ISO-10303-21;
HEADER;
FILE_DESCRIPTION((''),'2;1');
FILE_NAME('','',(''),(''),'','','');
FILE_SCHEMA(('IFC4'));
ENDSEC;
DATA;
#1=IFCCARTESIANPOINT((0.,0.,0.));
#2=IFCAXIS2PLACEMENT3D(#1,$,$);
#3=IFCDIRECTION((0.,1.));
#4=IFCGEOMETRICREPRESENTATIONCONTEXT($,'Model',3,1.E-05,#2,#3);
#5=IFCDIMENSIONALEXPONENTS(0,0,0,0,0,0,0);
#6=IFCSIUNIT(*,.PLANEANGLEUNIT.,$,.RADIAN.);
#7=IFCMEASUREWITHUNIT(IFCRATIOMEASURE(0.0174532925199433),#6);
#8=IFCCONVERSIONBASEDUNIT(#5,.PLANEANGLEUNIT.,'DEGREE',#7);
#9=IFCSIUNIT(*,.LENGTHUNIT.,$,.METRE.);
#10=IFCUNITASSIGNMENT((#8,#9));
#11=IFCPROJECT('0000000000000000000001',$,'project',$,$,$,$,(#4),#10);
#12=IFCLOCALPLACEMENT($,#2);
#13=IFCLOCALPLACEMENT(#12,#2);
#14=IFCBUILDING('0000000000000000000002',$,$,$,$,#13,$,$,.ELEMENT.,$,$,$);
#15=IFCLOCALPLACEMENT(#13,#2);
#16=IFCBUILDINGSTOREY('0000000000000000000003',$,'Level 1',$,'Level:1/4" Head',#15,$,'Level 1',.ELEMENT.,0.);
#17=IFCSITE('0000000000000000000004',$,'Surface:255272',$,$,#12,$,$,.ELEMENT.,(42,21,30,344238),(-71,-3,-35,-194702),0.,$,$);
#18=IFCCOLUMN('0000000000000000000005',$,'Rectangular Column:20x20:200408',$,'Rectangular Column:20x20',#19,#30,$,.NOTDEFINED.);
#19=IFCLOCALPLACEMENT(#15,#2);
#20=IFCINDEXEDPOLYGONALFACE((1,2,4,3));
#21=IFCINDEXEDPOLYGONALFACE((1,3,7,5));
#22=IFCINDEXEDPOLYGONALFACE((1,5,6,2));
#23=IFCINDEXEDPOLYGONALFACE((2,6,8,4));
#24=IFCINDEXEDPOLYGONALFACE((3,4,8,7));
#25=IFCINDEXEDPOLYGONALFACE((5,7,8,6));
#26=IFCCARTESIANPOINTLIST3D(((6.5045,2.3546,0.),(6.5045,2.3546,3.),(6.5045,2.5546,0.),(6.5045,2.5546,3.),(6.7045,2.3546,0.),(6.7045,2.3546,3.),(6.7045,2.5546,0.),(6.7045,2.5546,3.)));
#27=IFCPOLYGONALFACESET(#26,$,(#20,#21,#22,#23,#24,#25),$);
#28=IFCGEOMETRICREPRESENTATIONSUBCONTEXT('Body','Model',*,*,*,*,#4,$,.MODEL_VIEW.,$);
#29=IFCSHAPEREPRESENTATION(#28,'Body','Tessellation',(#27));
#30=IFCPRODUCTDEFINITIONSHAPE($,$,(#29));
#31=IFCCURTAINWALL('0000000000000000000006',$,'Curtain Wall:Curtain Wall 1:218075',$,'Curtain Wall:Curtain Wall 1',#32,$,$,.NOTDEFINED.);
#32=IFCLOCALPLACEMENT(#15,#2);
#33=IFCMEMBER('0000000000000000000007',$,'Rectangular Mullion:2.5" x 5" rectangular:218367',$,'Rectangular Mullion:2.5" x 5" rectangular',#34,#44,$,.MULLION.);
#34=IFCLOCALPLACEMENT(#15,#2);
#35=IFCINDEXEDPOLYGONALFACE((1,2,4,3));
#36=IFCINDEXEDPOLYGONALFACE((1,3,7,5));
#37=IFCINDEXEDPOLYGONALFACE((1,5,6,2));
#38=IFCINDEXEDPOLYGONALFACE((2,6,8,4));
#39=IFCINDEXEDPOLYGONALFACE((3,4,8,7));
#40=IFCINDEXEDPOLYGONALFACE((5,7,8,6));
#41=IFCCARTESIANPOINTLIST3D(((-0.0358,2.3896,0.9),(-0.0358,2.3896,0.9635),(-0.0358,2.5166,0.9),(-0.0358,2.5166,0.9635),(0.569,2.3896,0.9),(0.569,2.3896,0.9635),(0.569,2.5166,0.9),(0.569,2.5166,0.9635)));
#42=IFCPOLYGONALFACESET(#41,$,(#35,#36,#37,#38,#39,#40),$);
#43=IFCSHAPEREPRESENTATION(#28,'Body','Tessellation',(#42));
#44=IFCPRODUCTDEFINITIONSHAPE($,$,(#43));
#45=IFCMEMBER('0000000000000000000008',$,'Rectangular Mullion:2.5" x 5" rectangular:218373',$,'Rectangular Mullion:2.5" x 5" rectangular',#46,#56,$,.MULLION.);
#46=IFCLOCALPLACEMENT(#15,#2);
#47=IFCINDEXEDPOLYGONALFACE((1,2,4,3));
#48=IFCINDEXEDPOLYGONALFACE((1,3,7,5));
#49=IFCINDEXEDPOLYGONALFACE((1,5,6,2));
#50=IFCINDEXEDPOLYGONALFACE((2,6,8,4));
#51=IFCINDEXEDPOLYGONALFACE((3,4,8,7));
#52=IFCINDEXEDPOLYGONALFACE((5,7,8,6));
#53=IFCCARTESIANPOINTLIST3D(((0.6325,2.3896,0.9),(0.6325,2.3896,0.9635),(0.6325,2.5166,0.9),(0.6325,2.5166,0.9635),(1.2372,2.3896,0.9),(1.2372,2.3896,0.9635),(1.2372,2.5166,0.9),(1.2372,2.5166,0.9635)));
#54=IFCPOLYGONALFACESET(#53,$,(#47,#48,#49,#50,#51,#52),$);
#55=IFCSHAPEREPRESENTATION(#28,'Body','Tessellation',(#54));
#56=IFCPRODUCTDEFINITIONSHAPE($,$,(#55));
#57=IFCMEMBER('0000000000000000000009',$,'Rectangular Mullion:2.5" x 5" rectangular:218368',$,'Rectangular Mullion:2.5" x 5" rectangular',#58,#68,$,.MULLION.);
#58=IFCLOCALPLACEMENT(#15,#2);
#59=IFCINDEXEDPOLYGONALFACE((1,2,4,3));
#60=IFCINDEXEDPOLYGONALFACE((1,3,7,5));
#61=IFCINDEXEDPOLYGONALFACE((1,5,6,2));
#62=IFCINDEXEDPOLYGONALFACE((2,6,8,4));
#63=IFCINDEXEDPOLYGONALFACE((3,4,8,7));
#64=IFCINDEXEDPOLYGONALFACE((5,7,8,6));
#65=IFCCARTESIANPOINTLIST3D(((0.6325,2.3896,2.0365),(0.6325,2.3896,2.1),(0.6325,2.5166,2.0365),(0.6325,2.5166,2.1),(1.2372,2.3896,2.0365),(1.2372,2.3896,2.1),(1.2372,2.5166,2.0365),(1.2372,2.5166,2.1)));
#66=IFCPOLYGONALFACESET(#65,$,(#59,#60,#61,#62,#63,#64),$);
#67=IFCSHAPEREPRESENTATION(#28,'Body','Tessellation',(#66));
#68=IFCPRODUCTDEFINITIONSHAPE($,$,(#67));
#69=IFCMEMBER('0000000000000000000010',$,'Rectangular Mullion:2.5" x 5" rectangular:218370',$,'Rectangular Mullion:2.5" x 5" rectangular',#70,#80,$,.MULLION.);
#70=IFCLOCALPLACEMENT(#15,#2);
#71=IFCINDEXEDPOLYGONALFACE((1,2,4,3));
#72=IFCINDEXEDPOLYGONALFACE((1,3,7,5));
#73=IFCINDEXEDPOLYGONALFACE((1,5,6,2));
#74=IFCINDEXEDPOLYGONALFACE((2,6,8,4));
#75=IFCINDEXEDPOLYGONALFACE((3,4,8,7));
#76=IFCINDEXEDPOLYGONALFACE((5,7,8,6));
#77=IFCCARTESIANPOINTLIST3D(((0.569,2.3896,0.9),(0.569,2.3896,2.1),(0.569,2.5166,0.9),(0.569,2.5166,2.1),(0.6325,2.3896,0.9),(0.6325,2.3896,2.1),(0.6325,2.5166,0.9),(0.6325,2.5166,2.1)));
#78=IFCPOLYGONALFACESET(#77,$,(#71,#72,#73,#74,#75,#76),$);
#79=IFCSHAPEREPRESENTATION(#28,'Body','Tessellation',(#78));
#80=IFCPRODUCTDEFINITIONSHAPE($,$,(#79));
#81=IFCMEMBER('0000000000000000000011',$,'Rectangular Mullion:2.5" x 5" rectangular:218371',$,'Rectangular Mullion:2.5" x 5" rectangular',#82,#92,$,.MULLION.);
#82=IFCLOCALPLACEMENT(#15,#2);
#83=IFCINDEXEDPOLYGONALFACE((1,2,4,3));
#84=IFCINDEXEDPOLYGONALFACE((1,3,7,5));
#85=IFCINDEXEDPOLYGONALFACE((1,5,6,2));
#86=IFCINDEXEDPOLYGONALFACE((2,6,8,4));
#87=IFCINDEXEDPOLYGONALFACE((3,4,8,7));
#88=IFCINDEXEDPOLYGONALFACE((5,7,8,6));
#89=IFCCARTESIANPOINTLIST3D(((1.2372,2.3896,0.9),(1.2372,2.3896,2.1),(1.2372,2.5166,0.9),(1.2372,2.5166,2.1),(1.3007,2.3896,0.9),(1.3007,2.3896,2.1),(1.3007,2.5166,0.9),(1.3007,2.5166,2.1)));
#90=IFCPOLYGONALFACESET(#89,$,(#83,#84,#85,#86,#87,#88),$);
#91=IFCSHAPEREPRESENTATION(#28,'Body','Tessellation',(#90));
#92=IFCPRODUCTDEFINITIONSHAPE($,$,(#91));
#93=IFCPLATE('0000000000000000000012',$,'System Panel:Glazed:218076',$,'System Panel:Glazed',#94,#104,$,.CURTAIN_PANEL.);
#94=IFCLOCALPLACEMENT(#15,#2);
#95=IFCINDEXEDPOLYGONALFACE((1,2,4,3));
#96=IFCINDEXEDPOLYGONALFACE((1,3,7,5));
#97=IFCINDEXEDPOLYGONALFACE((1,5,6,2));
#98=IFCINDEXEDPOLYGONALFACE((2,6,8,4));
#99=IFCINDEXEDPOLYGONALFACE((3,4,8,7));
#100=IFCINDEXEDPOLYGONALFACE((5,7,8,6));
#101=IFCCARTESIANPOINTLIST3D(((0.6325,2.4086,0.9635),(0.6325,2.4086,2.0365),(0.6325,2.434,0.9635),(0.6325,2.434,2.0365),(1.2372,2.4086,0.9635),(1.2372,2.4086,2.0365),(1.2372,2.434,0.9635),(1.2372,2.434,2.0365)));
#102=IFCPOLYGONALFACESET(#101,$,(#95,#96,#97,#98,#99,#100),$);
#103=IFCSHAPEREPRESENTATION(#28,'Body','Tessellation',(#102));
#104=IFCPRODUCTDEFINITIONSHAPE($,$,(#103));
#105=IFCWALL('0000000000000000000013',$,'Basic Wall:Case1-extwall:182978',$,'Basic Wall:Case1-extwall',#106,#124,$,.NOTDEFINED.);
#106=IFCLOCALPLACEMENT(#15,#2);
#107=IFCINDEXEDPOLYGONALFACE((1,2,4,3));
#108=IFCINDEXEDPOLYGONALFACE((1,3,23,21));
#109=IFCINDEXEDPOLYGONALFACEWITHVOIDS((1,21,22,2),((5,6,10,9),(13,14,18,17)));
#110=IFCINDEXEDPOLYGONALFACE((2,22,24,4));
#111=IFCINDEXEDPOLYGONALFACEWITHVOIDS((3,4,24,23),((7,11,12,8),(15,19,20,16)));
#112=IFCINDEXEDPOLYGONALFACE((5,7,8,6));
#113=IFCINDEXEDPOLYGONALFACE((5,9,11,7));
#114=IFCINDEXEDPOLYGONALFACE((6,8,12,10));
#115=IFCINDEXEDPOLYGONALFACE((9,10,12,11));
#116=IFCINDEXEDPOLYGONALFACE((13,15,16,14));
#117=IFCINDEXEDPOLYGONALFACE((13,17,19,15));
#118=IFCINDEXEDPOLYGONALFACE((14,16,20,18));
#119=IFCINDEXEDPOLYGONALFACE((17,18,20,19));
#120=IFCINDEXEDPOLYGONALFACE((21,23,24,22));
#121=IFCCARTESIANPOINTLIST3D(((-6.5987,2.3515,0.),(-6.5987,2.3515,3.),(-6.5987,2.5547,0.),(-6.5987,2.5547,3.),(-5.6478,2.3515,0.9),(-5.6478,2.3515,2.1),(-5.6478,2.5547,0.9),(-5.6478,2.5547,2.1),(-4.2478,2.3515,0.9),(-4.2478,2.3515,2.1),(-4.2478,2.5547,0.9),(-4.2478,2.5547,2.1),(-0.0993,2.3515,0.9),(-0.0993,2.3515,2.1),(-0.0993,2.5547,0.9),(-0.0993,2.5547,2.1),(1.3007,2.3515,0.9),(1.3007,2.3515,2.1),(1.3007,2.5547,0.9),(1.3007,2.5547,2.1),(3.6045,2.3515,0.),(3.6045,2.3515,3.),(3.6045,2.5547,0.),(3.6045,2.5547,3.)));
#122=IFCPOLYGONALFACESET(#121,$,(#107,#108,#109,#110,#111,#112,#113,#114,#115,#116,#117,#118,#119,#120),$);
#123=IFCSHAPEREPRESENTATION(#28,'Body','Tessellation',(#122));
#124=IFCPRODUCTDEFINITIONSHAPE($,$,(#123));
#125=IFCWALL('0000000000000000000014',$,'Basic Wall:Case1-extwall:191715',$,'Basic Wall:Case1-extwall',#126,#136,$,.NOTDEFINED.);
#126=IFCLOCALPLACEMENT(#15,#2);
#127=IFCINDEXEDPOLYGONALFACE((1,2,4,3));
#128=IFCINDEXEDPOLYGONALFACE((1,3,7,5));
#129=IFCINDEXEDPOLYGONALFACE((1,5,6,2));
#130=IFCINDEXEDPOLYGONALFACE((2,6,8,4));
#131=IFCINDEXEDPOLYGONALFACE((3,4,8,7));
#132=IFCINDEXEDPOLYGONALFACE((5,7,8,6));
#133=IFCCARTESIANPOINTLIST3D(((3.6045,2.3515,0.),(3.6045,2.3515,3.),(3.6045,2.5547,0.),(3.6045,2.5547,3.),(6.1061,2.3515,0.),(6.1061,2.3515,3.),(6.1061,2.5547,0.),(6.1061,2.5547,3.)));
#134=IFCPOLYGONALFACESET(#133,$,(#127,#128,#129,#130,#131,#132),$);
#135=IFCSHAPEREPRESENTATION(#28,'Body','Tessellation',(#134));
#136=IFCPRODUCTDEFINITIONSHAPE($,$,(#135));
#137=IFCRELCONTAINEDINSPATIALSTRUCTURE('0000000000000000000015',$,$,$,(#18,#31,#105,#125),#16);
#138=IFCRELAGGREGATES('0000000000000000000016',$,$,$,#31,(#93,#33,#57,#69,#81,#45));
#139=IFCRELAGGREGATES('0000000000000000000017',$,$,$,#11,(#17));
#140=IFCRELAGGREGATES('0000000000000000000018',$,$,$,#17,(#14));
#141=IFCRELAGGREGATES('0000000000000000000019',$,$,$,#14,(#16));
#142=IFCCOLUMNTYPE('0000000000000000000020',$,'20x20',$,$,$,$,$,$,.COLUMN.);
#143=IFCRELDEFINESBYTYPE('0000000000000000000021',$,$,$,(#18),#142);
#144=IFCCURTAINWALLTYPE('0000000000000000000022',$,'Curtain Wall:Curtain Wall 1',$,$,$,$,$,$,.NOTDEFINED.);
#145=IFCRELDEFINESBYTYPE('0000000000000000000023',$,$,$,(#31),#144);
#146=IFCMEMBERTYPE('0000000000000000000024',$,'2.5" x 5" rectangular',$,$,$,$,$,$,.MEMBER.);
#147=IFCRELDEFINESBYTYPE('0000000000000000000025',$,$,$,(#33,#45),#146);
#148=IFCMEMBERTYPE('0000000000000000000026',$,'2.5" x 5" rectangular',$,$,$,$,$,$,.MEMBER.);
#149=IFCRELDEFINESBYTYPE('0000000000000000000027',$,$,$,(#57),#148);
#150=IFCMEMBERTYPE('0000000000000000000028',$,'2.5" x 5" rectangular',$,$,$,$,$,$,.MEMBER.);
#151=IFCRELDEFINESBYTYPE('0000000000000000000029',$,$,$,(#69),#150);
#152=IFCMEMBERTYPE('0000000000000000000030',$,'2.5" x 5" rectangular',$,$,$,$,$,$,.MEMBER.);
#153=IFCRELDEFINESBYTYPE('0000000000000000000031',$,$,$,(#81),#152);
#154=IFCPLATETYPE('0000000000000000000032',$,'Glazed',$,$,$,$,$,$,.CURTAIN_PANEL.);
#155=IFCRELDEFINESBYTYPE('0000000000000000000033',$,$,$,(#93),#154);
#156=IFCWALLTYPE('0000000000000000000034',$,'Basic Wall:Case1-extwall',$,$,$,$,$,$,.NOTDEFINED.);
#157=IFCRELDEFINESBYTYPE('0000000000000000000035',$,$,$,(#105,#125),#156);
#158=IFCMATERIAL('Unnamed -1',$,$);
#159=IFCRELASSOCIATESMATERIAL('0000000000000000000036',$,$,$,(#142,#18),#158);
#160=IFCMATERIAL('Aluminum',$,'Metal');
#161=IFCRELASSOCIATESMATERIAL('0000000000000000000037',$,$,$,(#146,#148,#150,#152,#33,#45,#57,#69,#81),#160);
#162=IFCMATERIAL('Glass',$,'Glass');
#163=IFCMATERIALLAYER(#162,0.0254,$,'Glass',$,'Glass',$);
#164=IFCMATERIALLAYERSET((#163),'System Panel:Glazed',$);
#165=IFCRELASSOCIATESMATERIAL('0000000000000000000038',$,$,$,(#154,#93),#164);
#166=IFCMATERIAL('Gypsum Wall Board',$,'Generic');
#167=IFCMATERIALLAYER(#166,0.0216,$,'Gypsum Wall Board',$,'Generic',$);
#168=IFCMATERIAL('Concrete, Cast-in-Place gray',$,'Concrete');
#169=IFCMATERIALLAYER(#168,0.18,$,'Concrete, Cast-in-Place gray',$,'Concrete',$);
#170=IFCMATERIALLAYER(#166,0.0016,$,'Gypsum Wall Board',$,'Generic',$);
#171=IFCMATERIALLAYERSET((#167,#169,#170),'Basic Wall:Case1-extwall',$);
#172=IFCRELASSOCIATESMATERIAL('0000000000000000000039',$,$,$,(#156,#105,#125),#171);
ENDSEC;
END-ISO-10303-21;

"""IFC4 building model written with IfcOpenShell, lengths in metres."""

from ifc_helpers import new_model, entity, si_unit, converted_unit, direction, frame, frame_2d, origin, origin_2d_with_axis, place, context, subcontext, project, spatial, polyline, rectangle, extrude, clip, bounded_halfspace, shape, source, transform, mapped, material, layer, layer_set, layer_usage, material_profile, profile_set, profile_usage, type_object, type_shapes, element, fill, aggregate, save


model = new_model("IFC4")

# Units and contexts
model_context = context("Model", 3, precision=1e-05, world=origin(), true_north=direction((0.0, 1.0)))
body_context = subcontext(model_context, "Body", "Model", "MODEL_VIEW")
footprint_context = subcontext(model_context, "FootPrint", "Model", "MODEL_VIEW")
ifc_project = project(units=[converted_unit("PLANEANGLEUNIT", "DEGREE", entity("IfcRatioMeasure", 0.0174532925199433), si_unit("PLANEANGLEUNIT", "RADIAN"), dimensions=[0, 0, 0, 0, 0, 0, 0]), si_unit("LENGTHUNIT", "METRE")], contexts=[model_context])

# Site, building, storey
site_placement = place(None, origin())
site = spatial("IfcSite", under=ifc_project, at=site_placement, Name="Surface:255272", CompositionType="ELEMENT", RefLatitude=(42, 21, 30, 344238), RefLongitude=(-71, -3, -35, -194702), RefElevation=0.0)
building_placement = place(site_placement, origin())
building = spatial("IfcBuilding", under=site, at=building_placement, CompositionType="ELEMENT")
storey_placement = place(building_placement, origin())
storey = spatial("IfcBuildingStorey", under=building, at=storey_placement, Name="Level 1", ObjectType="Level:1/4\" Head", LongName="Level 1", CompositionType="ELEMENT", Elevation=0.0)

# Column
ifc_material_1 = material(Name="Unnamed -1")
ifc_material_profile_1 = material_profile(ifc_material_1, rectangle(XDim=0.2, YDim=0.2, at=origin_2d_with_axis()), Name="20x20")
ifc_profile_set_1 = profile_set([ifc_material_profile_1], Name="20x20")
ifc_profile_usage_1 = profile_usage(ifc_profile_set_1)
column_type = type_object("IfcColumnType", Name="20x20", PredefinedType="COLUMN", material=ifc_profile_set_1)
shared_shape_1 = source(origin(), body_context, "Body", "SweptSolid", [
    extrude(rectangle(XDim=0.2, YDim=0.2, at=origin_2d_with_axis()), frame((0.0, 0.0, 0.0), z_axis=(0.0, 0.0, 1.0), x_axis=(0.0, -1.0, 0.0)), (0.0, 0.0, 1.0), 3.0),
])
type_shapes(column_type, [shared_shape_1])
column_placement = place(storey_placement, frame((6.6045, 2.4546, 0.0)))
element("IfcColumn", 1, at=column_placement, inside=storey, type_object=column_type, material=ifc_profile_usage_1, Name="Rectangular Column:20x20:200408", ObjectType="Rectangular Column:20x20", PredefinedType="NOTDEFINED", context=body_context, shape_type="MappedRepresentation", body=[
    mapped(shared_shape_1, transform((0.0, 0.0, 0.0), scale=1.0)),
])

# Shared definitions
curtain_wall_type = type_object("IfcCurtainWallType", Name="Curtain Wall:Curtain Wall 1", PredefinedType="NOTDEFINED")
ifc_material_2 = material(Name="Aluminum", Category="Metal")
ifc_material_profile_2 = material_profile(ifc_material_2, rectangle(XDim=0.127, YDim=0.0635, at=origin_2d_with_axis()), Name="2.5\" x 5\" rectangular")
ifc_profile_set_2 = profile_set([ifc_material_profile_2], Name="2.5\" x 5\" rectangular")

# Curtain wall, members
curtain_wall_1_placement = place(storey_placement, origin())
curtain_wall_1 = element("IfcCurtainWall", 2, at=curtain_wall_1_placement, inside=storey, type_object=curtain_wall_type, Name="Curtain Wall:Curtain Wall 1:218075", ObjectType="Curtain Wall:Curtain Wall 1", PredefinedType="NOTDEFINED")
ifc_profile_usage_2 = profile_usage(ifc_profile_set_2)
member_type_1 = type_object("IfcMemberType", Name="2.5\" x 5\" rectangular", PredefinedType="MEMBER", material=ifc_profile_set_2)
shared_shape_2 = source(origin(), body_context, "Body", "SweptSolid", [
    extrude(rectangle(XDim=0.127, YDim=0.0635, at=origin_2d_with_axis()), frame((-0.0318, 0.0, -0.6048), z_axis=(0.0, 0.0, 1.0), x_axis=(0.0, -1.0, 0.0)), (0.0, 0.0, 1.0), 0.6048),
])
type_shapes(member_type_1, [shared_shape_2])
member_1_placement = place(storey_placement, frame((0.569, 2.4531, 0.9), z_axis=(1.0, -0.000007, 0.0), x_axis=(0.0, 0.0, -1.0)))
member_1 = element("IfcMember", 3, at=member_1_placement, type_object=member_type_1, material=ifc_profile_usage_2, Name="Rectangular Mullion:2.5\" x 5\" rectangular:218367", ObjectType="Rectangular Mullion:2.5\" x 5\" rectangular", PredefinedType="MULLION", context=body_context, shape_type="MappedRepresentation", body=[
    mapped(shared_shape_2, transform((0.0, 0.0, 0.0), scale=1.0)),
])
ifc_profile_usage_3 = profile_usage(ifc_profile_set_2)
member_2_placement = place(storey_placement, frame((1.2372, 2.4531, 0.9), z_axis=(1.0, -0.000007, 0.0), x_axis=(0.0, 0.0, -1.0)))
member_2 = element("IfcMember", 4, at=member_2_placement, type_object=member_type_1, material=ifc_profile_usage_3, Name="Rectangular Mullion:2.5\" x 5\" rectangular:218373", ObjectType="Rectangular Mullion:2.5\" x 5\" rectangular", PredefinedType="MULLION", context=body_context, shape_type="MappedRepresentation", body=[
    mapped(shared_shape_2, transform((0.0, 0.0, 0.0), scale=1.0)),
])
ifc_profile_usage_4 = profile_usage(ifc_profile_set_2)
member_type_2 = type_object("IfcMemberType", Name="2.5\" x 5\" rectangular", PredefinedType="MEMBER", material=ifc_profile_set_2)
shared_shape_3 = source(origin(), body_context, "Body", "SweptSolid", [
    extrude(rectangle(XDim=0.127, YDim=0.0635, at=origin_2d_with_axis()), frame((-0.0318, 0.0, -0.6048), z_axis=(0.0, 0.0, 1.0), x_axis=(0.0, -1.0, 0.0)), (0.0, 0.0, 1.0), 0.6048),
])
type_shapes(member_type_2, [shared_shape_3])
member_3_placement = place(storey_placement, frame((0.6325, 2.4531, 2.1), z_axis=(-1.0, 0.000007, 0.0), x_axis=(0.0, 0.0, 1.0)))
member_3 = element("IfcMember", 5, at=member_3_placement, type_object=member_type_2, material=ifc_profile_usage_4, Name="Rectangular Mullion:2.5\" x 5\" rectangular:218368", ObjectType="Rectangular Mullion:2.5\" x 5\" rectangular", PredefinedType="MULLION", context=body_context, shape_type="MappedRepresentation", body=[
    mapped(shared_shape_3, transform((0.0, 0.0, 0.0), scale=1.0)),
])
ifc_profile_usage_5 = profile_usage(ifc_profile_set_2)
member_type_3 = type_object("IfcMemberType", Name="2.5\" x 5\" rectangular", PredefinedType="MEMBER", material=ifc_profile_set_2)
shared_shape_4 = source(origin(), body_context, "Body", "SweptSolid", [
    extrude(rectangle(XDim=0.127, YDim=0.0635, at=origin_2d_with_axis()), frame((0.0, 0.0, -1.2), z_axis=(0.0, 0.0, 1.0), x_axis=(0.0, -1.0, 0.0)), (0.0, 0.0, 1.0), 1.2),
])
type_shapes(member_type_3, [shared_shape_4])
member_4_placement = place(storey_placement, frame((0.6007, 2.4531, 0.9), z_axis=(0.0, 0.0, -1.0), x_axis=(-1.0, 0.000007, 0.0)))
member_4 = element("IfcMember", 6, at=member_4_placement, type_object=member_type_3, material=ifc_profile_usage_5, Name="Rectangular Mullion:2.5\" x 5\" rectangular:218370", ObjectType="Rectangular Mullion:2.5\" x 5\" rectangular", PredefinedType="MULLION", context=body_context, shape_type="MappedRepresentation", body=[
    mapped(shared_shape_4, transform((0.0, 0.0, 0.0), scale=1.0)),
])
ifc_profile_usage_6 = profile_usage(ifc_profile_set_2)
member_type_4 = type_object("IfcMemberType", Name="2.5\" x 5\" rectangular", PredefinedType="MEMBER", material=ifc_profile_set_2)
shared_shape_5 = source(origin(), body_context, "Body", "SweptSolid", [
    extrude(rectangle(XDim=0.127, YDim=0.0635, at=origin_2d_with_axis()), frame((-0.0318, 0.0, -1.2), z_axis=(0.0, 0.0, 1.0), x_axis=(0.0, -1.0, 0.0)), (0.0, 0.0, 1.0), 1.2),
])
type_shapes(member_type_4, [shared_shape_5])
member_5_placement = place(storey_placement, frame((1.3007, 2.4531, 2.1)))
member_5 = element("IfcMember", 7, at=member_5_placement, type_object=member_type_4, material=ifc_profile_usage_6, Name="Rectangular Mullion:2.5\" x 5\" rectangular:218371", ObjectType="Rectangular Mullion:2.5\" x 5\" rectangular", PredefinedType="MULLION", context=body_context, shape_type="MappedRepresentation", body=[
    mapped(shared_shape_5, transform((0.0, 0.0, 0.0), scale=1.0)),
])

# Plate
ifc_material_3 = material(Name="Glass", Category="Glass")
ifc_layer_1 = layer(ifc_material_3, 0.0254, Name="Glass", Category="Glass")
ifc_layer_set_1 = layer_set([ifc_layer_1], Name="System Panel:Glazed")
ifc_layer_usage_1 = layer_usage(ifc_layer_set_1, "AXIS3", "POSITIVE", 0.1042)
plate_type_1 = type_object("IfcPlateType", Name="Glazed", PredefinedType="CURTAIN_PANEL", material=ifc_layer_set_1)
shared_shape_6 = source(origin(), body_context, "Body", "SweptSolid", [
    extrude(rectangle(XDim=0.0254, YDim=0.6048, at=frame_2d((0.0, 0.0), x_axis=(1.0, 0.0))), frame((0.3024, 0.0127, 0.0), z_axis=(0.0, 0.0, 1.0), x_axis=(0.0, 1.0, 0.0)), (0.0, 0.0, 1.0), 1.073),
])
cartesian_point_1 = entity("IfcCartesianPoint", [0.3945, 0.0132])
shared_shape_7 = source(frame((-0.3024, 0.0191, 0.0)), footprint_context, "FootPrint", "Curve2D", [
    entity("IfcPolyline", [cartesian_point_1, entity("IfcCartesianPoint", [0.3945, 0.0386]), entity("IfcCartesianPoint", [-0.2102, 0.0386]), entity("IfcCartesianPoint", [-0.2102, 0.0132]), cartesian_point_1]),
])
type_shapes(plate_type_1, [shared_shape_6, shared_shape_7])
plate_1_placement = place(curtain_wall_1_placement, frame((1.2372, 2.434, 0.9635), z_axis=(0.0, 0.0, 1.0), x_axis=(-1.0, 0.0, 0.0)))
plate_1 = element("IfcPlate", 8, at=plate_1_placement, type_object=plate_type_1, material=ifc_layer_usage_1, Name="System Panel:Glazed:218076", ObjectType="System Panel:Glazed", PredefinedType="CURTAIN_PANEL", shapes=[
    shape(body_context, "Body", "MappedRepresentation", [mapped(shared_shape_6, transform((0.0, 0.0, 0.0), scale=1.0))]),
    shape(body_context, "Body", "MappedRepresentation", [mapped(shared_shape_7, transform((0.0, 0.0, 0.0), scale=1.0))]),
])
aggregate(curtain_wall_1, [plate_1, member_1, member_3, member_4, member_5, member_2])

# Wall, opening
ifc_material_4 = material(Name="Gypsum Wall Board", Category="Generic")
ifc_layer_2 = layer(ifc_material_4, 0.0216, Name="Gypsum Wall Board", Category="Generic")
ifc_material_5 = material(Name="Concrete, Cast-in-Place gray", Category="Concrete")
ifc_layer_3 = layer(ifc_material_5, 0.18, Name="Concrete, Cast-in-Place gray", Category="Concrete")
ifc_layer_4 = layer(ifc_material_4, 0.0016, Name="Gypsum Wall Board", Category="Generic")
ifc_layer_set_2 = layer_set([ifc_layer_2, ifc_layer_3, ifc_layer_4], Name="Basic Wall:Case1-extwall")
ifc_layer_usage_2 = layer_usage(ifc_layer_set_2, "AXIS2", "NEGATIVE", 0.1016)
wall_type = type_object("IfcWallType", Name="Basic Wall:Case1-extwall", PredefinedType="NOTDEFINED", material=ifc_layer_set_2)
wall_1_placement = place(storey_placement, frame((3.6045, 2.4531, 0.0), z_axis=(0.0, 0.0, 1.0), x_axis=(-1.0, 0.000007, 0.0)))
wall_1 = element("IfcWall", 9, at=wall_1_placement, inside=storey, type_object=wall_type, material=ifc_layer_usage_2, Name="Basic Wall:Case1-extwall:182978", ObjectType="Basic Wall:Case1-extwall", PredefinedType="NOTDEFINED", context=body_context, shape_type="Clipping", body=[
    clip(extrude(rectangle(XDim=10.2032, YDim=0.2032, at=frame_2d((5.1016, 0.0), x_axis=(-1.0, 0.0))), origin(), (0.0, 0.0, 1.0), 3.0), bounded_halfspace(frame((0.0, -0.1016, 3.0), z_axis=(0.0, 0.0, -1.0), x_axis=(1.0, 0.0, 0.0)), True, frame((0.0, -0.1016, 3.0)), polyline([(0.0, 0.0), (10.2032, 0.0), (10.2032, 0.2032), (5.881, 0.2032), (5.7286, 0.2032), (0.0, 0.2032), (0.0, 0.0)]))),
])
opening_1_placement = place(wall_1_placement, frame((3.7038, 0.1016, 0.9)))
opening_1 = element("IfcOpeningElement", 10, at=opening_1_placement, cuts=wall_1, ObjectType="Opening", PredefinedType="OPENING", context=body_context, shape_type="SweptSolid", body=[
    extrude(rectangle(XDim=1.2, YDim=1.4, at=frame_2d((0.0, 0.0), x_axis=(1.0, 0.0))), frame((-0.7, -0.2032, 0.6), z_axis=(0.0, 1.0, 0.0), x_axis=(0.0, 0.0, -1.0)), (0.0, 0.0, 1.0), 0.2032),
])
fill(opening_1, curtain_wall_1)

# Opening
opening_2_placement = place(wall_1_placement, frame((9.2523, 0.1016, 0.9)))
element("IfcOpeningElement", 11, at=opening_2_placement, cuts=wall_1, ObjectType="Opening", PredefinedType="OPENING", context=body_context, shape_type="SweptSolid", body=[
    extrude(rectangle(XDim=1.2, YDim=1.4, at=frame_2d((0.0, 0.0), x_axis=(1.0, 0.0))), frame((-0.7, -0.2032, 0.6), z_axis=(0.0, 1.0, 0.0), x_axis=(0.0, 0.0, -1.0)), (0.0, 0.0, 1.0), 0.2032),
])

# Wall
ifc_layer_usage_3 = layer_usage(ifc_layer_set_2, "AXIS2", "NEGATIVE", 0.1016)
wall_2_placement = place(storey_placement, frame((3.6045, 2.4531, 0.0)))
element("IfcWall", 12, at=wall_2_placement, inside=storey, type_object=wall_type, material=ifc_layer_usage_3, Name="Basic Wall:Case1-extwall:191715", ObjectType="Basic Wall:Case1-extwall", PredefinedType="NOTDEFINED", context=body_context, shape_type="Clipping", body=[
    clip(extrude(rectangle(XDim=2.5016, YDim=0.2032, at=frame_2d((1.2508, 0.0), x_axis=(-1.0, 0.0))), origin(), (0.0, 0.0, 1.0), 3.0), bounded_halfspace(frame((0.0, -0.1016, 3.0), z_axis=(0.0, 0.0, -1.0), x_axis=(-1.0, 0.0, 0.0)), True, frame((0.0, -0.1016, 3.0)), polyline([(0.0, 0.0), (2.2984, 0.0), (2.5016, 0.0), (2.5016, 0.2032), (0.1016, 0.2032), (0.0, 0.2032), (0.0, 0.0)]))),
])

save(model, "model.ifc")
